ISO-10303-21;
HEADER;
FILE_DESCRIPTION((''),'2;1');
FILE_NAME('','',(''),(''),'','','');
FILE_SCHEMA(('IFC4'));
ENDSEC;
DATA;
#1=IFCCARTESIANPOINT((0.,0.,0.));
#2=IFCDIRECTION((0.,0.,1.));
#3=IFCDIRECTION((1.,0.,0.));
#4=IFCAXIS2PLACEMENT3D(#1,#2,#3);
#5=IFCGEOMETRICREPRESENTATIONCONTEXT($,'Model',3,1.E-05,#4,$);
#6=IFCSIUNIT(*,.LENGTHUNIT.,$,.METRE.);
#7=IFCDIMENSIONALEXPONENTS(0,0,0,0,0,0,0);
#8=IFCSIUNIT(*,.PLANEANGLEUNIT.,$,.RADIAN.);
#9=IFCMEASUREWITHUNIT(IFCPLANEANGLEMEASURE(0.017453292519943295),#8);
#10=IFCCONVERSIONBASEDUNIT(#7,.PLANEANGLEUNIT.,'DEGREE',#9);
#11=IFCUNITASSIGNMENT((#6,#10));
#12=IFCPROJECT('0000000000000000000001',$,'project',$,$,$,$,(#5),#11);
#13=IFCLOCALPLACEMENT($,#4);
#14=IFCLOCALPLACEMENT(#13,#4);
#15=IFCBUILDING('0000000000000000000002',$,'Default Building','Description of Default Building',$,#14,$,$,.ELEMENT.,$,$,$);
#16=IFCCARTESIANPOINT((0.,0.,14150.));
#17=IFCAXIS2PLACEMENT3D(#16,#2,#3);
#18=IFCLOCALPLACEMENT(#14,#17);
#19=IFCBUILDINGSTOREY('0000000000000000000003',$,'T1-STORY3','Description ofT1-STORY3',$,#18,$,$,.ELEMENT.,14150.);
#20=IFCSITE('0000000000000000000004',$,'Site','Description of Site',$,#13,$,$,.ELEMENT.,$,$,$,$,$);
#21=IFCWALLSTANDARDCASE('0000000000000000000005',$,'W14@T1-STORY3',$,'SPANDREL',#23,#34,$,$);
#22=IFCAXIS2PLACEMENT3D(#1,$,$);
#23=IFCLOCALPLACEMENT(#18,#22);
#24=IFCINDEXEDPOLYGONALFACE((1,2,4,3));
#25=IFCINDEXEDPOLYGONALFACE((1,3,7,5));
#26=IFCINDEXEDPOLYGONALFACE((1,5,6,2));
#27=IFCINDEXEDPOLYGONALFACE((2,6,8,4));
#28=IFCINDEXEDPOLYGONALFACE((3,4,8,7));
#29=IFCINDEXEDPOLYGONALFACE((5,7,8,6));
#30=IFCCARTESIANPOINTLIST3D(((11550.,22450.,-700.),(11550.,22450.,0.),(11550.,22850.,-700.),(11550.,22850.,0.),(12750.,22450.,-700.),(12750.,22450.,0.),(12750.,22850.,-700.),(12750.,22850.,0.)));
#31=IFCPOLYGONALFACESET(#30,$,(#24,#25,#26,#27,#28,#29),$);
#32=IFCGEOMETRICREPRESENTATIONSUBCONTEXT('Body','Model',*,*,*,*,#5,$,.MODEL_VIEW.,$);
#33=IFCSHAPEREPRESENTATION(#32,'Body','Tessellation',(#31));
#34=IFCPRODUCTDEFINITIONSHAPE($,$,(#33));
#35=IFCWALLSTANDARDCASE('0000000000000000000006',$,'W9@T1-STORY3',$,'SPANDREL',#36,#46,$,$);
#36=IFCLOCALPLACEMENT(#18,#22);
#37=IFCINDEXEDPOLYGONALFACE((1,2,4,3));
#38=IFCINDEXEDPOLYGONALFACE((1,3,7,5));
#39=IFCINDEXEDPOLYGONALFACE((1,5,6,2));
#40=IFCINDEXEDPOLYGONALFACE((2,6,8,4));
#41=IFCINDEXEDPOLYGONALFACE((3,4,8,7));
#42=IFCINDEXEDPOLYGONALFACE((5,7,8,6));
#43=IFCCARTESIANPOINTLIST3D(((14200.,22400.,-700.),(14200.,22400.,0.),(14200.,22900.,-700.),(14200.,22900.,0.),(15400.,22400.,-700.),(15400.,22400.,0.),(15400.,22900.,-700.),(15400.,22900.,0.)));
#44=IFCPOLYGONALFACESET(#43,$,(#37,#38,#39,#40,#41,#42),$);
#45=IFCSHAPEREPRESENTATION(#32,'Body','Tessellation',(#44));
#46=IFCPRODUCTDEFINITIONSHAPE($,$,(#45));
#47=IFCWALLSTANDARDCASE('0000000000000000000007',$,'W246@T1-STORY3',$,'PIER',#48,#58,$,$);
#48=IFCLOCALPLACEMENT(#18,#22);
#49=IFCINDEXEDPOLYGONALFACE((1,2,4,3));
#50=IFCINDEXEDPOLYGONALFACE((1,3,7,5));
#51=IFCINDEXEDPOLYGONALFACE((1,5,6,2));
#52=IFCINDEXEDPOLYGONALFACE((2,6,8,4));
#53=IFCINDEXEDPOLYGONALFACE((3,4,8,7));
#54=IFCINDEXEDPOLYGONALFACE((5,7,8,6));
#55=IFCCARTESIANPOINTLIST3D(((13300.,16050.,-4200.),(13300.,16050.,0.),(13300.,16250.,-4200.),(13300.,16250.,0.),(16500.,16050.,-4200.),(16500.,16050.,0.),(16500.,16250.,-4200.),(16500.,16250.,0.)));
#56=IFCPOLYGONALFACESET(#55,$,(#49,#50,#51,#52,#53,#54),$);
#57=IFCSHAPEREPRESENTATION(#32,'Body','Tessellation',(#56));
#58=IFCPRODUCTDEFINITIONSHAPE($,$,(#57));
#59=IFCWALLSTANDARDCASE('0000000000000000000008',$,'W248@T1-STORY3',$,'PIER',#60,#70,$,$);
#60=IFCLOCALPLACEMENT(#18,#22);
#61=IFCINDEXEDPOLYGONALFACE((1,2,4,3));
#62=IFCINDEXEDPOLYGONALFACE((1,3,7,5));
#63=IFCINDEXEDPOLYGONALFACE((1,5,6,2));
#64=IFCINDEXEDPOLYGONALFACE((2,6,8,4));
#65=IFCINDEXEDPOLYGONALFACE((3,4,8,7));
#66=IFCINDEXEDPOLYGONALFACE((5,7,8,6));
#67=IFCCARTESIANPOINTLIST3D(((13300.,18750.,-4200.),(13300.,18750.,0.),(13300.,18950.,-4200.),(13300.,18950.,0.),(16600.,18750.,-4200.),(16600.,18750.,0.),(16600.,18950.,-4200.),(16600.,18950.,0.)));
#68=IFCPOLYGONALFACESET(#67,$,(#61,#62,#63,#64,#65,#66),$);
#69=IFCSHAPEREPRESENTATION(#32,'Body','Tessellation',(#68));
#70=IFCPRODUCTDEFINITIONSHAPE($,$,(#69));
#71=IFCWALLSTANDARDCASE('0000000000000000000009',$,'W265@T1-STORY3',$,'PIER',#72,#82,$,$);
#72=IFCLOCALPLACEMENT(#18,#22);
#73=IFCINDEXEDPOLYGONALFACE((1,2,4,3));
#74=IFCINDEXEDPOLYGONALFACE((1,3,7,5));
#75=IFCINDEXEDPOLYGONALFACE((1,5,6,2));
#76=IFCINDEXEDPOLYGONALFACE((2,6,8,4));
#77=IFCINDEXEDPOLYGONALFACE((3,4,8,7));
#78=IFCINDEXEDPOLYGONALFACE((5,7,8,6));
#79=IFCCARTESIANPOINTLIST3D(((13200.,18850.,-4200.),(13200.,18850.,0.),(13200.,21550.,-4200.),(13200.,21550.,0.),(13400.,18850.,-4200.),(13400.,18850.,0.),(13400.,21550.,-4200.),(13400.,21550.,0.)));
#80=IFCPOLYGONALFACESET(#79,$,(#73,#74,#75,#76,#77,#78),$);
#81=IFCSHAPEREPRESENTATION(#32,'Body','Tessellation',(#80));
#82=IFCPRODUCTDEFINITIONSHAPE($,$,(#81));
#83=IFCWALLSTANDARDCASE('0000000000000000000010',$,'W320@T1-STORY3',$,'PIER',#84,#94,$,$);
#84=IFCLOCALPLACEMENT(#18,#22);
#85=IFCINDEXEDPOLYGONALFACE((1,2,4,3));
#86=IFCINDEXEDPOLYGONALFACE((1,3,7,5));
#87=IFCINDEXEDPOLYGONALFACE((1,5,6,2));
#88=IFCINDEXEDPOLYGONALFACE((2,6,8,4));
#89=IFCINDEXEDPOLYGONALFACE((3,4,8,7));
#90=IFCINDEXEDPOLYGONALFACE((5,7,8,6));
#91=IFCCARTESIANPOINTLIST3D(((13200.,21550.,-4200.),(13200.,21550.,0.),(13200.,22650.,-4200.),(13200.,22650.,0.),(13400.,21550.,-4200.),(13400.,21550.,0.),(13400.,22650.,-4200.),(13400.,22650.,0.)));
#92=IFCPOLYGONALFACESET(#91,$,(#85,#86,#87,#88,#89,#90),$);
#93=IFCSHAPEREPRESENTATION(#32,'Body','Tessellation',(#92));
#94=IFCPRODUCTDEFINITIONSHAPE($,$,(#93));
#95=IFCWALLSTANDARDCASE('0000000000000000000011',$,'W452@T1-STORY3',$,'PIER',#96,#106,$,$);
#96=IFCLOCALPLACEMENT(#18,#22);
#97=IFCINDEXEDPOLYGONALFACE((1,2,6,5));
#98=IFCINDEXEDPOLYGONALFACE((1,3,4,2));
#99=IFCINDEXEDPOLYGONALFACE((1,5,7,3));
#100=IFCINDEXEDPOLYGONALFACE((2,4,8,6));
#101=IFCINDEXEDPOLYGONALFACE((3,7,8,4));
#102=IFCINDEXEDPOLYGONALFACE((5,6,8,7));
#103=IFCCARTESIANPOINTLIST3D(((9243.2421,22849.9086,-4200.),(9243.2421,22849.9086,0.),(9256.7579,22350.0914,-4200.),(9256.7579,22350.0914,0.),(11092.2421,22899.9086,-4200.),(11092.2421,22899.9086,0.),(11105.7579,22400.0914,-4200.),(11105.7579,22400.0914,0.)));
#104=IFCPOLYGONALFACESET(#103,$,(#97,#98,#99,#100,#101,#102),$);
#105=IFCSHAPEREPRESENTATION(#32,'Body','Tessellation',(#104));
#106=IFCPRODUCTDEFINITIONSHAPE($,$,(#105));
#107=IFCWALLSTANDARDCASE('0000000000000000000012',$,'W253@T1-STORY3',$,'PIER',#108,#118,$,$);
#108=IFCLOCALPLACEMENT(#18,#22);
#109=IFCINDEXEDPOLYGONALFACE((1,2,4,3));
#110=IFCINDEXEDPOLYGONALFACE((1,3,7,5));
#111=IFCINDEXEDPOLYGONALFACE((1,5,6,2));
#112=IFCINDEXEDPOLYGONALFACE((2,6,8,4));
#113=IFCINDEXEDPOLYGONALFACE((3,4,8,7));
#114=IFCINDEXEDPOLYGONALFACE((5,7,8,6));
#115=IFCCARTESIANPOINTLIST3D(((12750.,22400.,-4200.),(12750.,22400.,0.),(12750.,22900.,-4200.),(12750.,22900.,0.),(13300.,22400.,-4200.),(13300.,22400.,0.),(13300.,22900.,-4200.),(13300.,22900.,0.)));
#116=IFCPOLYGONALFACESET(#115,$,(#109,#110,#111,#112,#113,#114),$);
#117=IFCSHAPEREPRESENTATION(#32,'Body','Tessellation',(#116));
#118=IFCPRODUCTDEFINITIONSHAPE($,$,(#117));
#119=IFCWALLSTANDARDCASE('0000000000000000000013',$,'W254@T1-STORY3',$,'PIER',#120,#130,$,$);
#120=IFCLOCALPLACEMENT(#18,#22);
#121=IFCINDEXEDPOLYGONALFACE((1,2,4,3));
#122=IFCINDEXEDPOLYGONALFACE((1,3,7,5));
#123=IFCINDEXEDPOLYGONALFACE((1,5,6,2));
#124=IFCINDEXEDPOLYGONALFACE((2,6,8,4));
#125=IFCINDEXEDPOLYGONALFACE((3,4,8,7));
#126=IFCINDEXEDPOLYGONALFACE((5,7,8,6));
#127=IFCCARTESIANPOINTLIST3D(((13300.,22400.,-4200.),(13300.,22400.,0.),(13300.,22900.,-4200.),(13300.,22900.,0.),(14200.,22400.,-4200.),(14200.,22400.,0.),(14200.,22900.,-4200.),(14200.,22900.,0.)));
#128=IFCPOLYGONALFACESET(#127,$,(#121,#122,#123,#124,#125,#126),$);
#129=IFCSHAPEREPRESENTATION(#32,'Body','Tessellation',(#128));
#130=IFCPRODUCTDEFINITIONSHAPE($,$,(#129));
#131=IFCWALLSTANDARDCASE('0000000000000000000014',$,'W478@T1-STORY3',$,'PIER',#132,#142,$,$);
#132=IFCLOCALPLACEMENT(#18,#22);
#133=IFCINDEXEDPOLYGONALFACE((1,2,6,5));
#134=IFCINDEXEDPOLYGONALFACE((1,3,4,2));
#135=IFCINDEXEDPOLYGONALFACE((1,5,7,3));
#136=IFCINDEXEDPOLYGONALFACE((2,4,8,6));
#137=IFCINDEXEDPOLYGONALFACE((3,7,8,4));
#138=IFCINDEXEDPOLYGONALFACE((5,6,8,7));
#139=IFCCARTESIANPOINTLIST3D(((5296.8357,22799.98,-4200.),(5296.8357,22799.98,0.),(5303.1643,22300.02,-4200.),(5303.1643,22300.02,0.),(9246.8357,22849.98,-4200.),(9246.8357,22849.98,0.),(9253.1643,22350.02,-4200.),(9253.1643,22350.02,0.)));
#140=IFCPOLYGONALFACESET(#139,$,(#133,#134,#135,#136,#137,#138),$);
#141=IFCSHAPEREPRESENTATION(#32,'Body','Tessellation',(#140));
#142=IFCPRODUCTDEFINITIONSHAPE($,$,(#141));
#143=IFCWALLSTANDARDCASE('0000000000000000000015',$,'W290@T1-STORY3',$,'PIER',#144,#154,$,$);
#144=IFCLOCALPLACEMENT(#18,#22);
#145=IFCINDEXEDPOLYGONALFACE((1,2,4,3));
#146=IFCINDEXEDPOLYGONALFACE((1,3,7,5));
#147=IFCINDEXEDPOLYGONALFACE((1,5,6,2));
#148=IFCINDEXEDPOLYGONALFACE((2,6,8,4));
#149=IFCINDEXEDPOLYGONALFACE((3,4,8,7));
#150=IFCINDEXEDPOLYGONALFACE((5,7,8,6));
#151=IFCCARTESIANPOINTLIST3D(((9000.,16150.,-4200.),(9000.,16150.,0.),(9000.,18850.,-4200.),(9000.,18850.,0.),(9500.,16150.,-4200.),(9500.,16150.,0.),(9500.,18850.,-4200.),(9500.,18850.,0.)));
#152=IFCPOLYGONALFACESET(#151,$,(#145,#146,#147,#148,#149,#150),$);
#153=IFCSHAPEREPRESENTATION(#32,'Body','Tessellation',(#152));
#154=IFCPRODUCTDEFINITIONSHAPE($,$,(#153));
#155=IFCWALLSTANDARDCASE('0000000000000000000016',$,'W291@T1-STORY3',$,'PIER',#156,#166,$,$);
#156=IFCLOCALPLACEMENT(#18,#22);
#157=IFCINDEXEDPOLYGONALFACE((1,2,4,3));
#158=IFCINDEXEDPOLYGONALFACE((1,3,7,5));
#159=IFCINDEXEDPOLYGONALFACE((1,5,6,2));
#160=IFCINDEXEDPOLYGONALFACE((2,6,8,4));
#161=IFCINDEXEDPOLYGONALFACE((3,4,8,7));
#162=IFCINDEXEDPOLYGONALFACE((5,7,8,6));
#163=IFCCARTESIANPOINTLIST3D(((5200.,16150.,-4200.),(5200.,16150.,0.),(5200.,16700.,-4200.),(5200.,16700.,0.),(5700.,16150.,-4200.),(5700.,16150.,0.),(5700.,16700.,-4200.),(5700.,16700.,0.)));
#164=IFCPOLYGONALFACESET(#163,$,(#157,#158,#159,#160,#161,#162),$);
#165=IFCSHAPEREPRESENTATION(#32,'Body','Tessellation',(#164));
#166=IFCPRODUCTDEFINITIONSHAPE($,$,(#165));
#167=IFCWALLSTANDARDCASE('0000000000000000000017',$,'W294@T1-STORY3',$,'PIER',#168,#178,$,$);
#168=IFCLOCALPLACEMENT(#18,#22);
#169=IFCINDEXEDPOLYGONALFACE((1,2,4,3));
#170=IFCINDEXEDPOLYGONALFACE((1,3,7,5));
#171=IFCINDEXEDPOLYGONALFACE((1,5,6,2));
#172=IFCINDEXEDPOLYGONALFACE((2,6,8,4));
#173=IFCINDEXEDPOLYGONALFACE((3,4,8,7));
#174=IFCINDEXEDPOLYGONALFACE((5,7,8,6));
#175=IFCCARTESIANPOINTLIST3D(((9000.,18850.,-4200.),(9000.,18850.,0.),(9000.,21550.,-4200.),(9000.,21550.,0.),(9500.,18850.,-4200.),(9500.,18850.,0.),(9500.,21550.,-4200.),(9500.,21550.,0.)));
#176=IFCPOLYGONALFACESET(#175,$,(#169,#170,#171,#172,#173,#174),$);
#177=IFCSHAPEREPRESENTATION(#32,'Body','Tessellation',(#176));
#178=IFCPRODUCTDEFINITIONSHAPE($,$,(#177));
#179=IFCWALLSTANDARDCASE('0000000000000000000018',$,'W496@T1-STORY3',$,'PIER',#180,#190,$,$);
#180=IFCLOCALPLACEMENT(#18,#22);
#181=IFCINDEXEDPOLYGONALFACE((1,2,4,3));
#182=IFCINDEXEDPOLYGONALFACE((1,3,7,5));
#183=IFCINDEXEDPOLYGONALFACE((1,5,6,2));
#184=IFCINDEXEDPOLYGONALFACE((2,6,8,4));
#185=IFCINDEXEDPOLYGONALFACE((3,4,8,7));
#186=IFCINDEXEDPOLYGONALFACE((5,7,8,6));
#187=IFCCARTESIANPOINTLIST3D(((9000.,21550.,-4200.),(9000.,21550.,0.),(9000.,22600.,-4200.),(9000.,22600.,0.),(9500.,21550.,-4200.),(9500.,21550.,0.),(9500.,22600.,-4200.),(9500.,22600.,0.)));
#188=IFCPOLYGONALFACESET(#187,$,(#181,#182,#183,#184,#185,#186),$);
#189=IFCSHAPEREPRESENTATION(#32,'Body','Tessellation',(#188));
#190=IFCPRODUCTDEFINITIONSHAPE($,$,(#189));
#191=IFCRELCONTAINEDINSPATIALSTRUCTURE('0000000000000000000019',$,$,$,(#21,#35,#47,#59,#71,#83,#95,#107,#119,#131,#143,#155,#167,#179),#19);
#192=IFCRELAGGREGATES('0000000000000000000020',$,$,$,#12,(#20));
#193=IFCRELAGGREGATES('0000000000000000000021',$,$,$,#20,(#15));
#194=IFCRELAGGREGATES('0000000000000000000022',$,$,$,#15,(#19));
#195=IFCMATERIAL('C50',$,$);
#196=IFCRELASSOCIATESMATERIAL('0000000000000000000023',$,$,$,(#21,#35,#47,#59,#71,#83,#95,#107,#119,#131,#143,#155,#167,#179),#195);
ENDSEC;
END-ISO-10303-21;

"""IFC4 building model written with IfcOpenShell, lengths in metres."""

from ifc_helpers import new_model, entity, si_unit, converted_unit, frame, origin_with_axes, place, context, subcontext, project, spatial, indexed_curve, outline, extrude, material, element, save


model = new_model("IFC4")

# Units and contexts
model_context = context("Model", 3, precision=1e-05, world=origin_with_axes())
body_context = subcontext(model_context, "Body", "Model", "MODEL_VIEW")
ifc_project = project(units=[si_unit("LENGTHUNIT", "METRE"), converted_unit("PLANEANGLEUNIT", "DEGREE", entity("IfcPlaneAngleMeasure", 0.017453292519943295), si_unit("PLANEANGLEUNIT", "RADIAN"), dimensions=[0, 0, 0, 0, 0, 0, 0])], contexts=[model_context])

# Site, building, storey
site_placement = place(None, origin_with_axes())
site = spatial("IfcSite", under=ifc_project, at=site_placement, Name="Site", Description="Description of Site", CompositionType="ELEMENT")
building_placement = place(site_placement, origin_with_axes())
building = spatial("IfcBuilding", under=site, at=building_placement, Name="Default Building", Description="Description of Default Building", CompositionType="ELEMENT")
storey_placement = place(building_placement, frame((0.0, 0.0, 14150.0), z_axis=(0.0, 0.0, 1.0), x_axis=(1.0, 0.0, 0.0)))
storey = spatial("IfcBuildingStorey", under=building, at=storey_placement, Name="T1-STORY3", Description="Description ofT1-STORY3", CompositionType="ELEMENT", Elevation=14150.0)

# Shared definitions
ifc_material_1 = material(Name="C50")

# Walls
wall_1_placement = place(storey_placement, frame((11550.0, 22650.0, -700.0), z_axis=(0.0, 0.0, 1.0), x_axis=(1.0, 0.0, 0.0)))
element("IfcWallStandardCase", 1, at=wall_1_placement, inside=storey, material=ifc_material_1, Name="W14@T1-STORY3", ObjectType="SPANDREL", context=body_context, shape_type="SweptSolid", body=[
    extrude(outline(indexed_curve([(0.0, -200.0), (0.0, 200.0), (1200.0, 200.0), (1200.0, -200.0), (0.0, -200.0)], self_intersect=False)), origin_with_axes(), (0.0, 0.0, 1.0), 700.0),
])
wall_2_placement = place(storey_placement, frame((14200.0, 22650.0, -700.0), z_axis=(0.0, 0.0, 1.0), x_axis=(1.0, 0.0, 0.0)))
element("IfcWallStandardCase", 2, at=wall_2_placement, inside=storey, material=ifc_material_1, Name="W9@T1-STORY3", ObjectType="SPANDREL", context=body_context, shape_type="SweptSolid", body=[
    extrude(outline(indexed_curve([(0.0, -250.0), (0.0, 250.0), (1200.0, 250.0), (1200.0, -250.0), (0.0, -250.0)], self_intersect=False)), origin_with_axes(), (0.0, 0.0, 1.0), 700.0),
])
wall_3_placement = place(storey_placement, frame((13300.0, 16150.0, -4200.0), z_axis=(0.0, 0.0, 1.0), x_axis=(1.0, 0.0, 0.0)))
element("IfcWallStandardCase", 3, at=wall_3_placement, inside=storey, material=ifc_material_1, Name="W246@T1-STORY3", ObjectType="PIER", context=body_context, shape_type="SweptSolid", body=[
    extrude(outline(indexed_curve([(0.0, -100.0), (0.0, 100.0), (3200.0, 100.0), (3200.0, -100.0), (0.0, -100.0)], self_intersect=False)), origin_with_axes(), (0.0, 0.0, 1.0), 4200.0),
])
wall_4_placement = place(storey_placement, frame((13300.0, 18850.0, -4200.0), z_axis=(0.0, 0.0, 1.0), x_axis=(1.0, 0.0, 0.0)))
element("IfcWallStandardCase", 4, at=wall_4_placement, inside=storey, material=ifc_material_1, Name="W248@T1-STORY3", ObjectType="PIER", context=body_context, shape_type="SweptSolid", body=[
    extrude(outline(indexed_curve([(0.0, -100.0), (0.0, 100.0), (3300.0, 100.0), (3300.0, -100.0), (0.0, -100.0)], self_intersect=False)), origin_with_axes(), (0.0, 0.0, 1.0), 4200.0),
])
wall_5_placement = place(storey_placement, frame((13300.0, 18850.0, -4200.0), z_axis=(0.0, 0.0, 1.0), x_axis=(0.0, 1.0, 0.0)))
element("IfcWallStandardCase", 5, at=wall_5_placement, inside=storey, material=ifc_material_1, Name="W265@T1-STORY3", ObjectType="PIER", context=body_context, shape_type="SweptSolid", body=[
    extrude(outline(indexed_curve([(0.0, -100.0), (0.0, 100.0), (2700.0, 100.0), (2700.0, -100.0), (0.0, -100.0)], self_intersect=False)), origin_with_axes(), (0.0, 0.0, 1.0), 4200.0),
])
wall_6_placement = place(storey_placement, frame((13300.0, 21550.0, -4200.0), z_axis=(0.0, 0.0, 1.0), x_axis=(0.0, 1.0, 0.0)))
element("IfcWallStandardCase", 6, at=wall_6_placement, inside=storey, material=ifc_material_1, Name="W320@T1-STORY3", ObjectType="PIER", context=body_context, shape_type="SweptSolid", body=[
    extrude(outline(indexed_curve([(0.0, -100.0), (0.0, 100.0), (1100.0, 100.0), (1100.0, -100.0), (0.0, -100.0)], self_intersect=False)), origin_with_axes(), (0.0, 0.0, 1.0), 4200.0),
])
wall_7_placement = place(storey_placement, frame((9250.0, 22600.0, -4200.0), z_axis=(0.0, 0.0, 1.0), x_axis=(0.999635, 0.027032, 0.0)))
element("IfcWallStandardCase", 7, at=wall_7_placement, inside=storey, material=ifc_material_1, Name="W452@T1-STORY3", ObjectType="PIER", context=body_context, shape_type="SweptSolid", body=[
    extrude(outline(indexed_curve([(0.0, -250.0), (0.0, 250.0), (1849.6759, 250.0), (1849.6759, -250.0), (0.0, -250.0)], self_intersect=False)), origin_with_axes(), (0.0, 0.0, 1.0), 4200.0),
])
wall_8_placement = place(storey_placement, frame((12750.0, 22650.0, -4200.0), z_axis=(0.0, 0.0, 1.0), x_axis=(1.0, 0.0, 0.0)))
element("IfcWallStandardCase", 8, at=wall_8_placement, inside=storey, material=ifc_material_1, Name="W253@T1-STORY3", ObjectType="PIER", context=body_context, shape_type="SweptSolid", body=[
    extrude(outline(indexed_curve([(0.0, -250.0), (0.0, 250.0), (550.0, 250.0), (550.0, -250.0), (0.0, -250.0)], self_intersect=False)), origin_with_axes(), (0.0, 0.0, 1.0), 4200.0),
])
wall_9_placement = place(storey_placement, frame((13300.0, 22650.0, -4200.0), z_axis=(0.0, 0.0, 1.0), x_axis=(1.0, 0.0, 0.0)))
element("IfcWallStandardCase", 9, at=wall_9_placement, inside=storey, material=ifc_material_1, Name="W254@T1-STORY3", ObjectType="PIER", context=body_context, shape_type="SweptSolid", body=[
    extrude(outline(indexed_curve([(0.0, -250.0), (0.0, 250.0), (900.0, 250.0), (900.0, -250.0), (0.0, -250.0)], self_intersect=False)), origin_with_axes(), (0.0, 0.0, 1.0), 4200.0),
])
wall_10_placement = place(storey_placement, frame((5300.0, 22550.0, -4200.0), z_axis=(0.0, 0.0, 1.0), x_axis=(0.99992, 0.012657, 0.0)))
element("IfcWallStandardCase", 10, at=wall_10_placement, inside=storey, material=ifc_material_1, Name="W478@T1-STORY3", ObjectType="PIER", context=body_context, shape_type="SweptSolid", body=[
    extrude(outline(indexed_curve([(0.0, -250.0), (0.0, 250.0), (3950.3164, 250.0), (3950.3164, -250.0), (0.0, -250.0)], self_intersect=False)), origin_with_axes(), (0.0, 0.0, 1.0), 4200.0),
])
wall_11_placement = place(storey_placement, frame((9250.0, 16150.0, -4200.0), z_axis=(0.0, 0.0, 1.0), x_axis=(0.0, 1.0, 0.0)))
element("IfcWallStandardCase", 11, at=wall_11_placement, inside=storey, material=ifc_material_1, Name="W290@T1-STORY3", ObjectType="PIER", context=body_context, shape_type="SweptSolid", body=[
    extrude(outline(indexed_curve([(0.0, -250.0), (0.0, 250.0), (2700.0, 250.0), (2700.0, -250.0), (0.0, -250.0)], self_intersect=False)), origin_with_axes(), (0.0, 0.0, 1.0), 4200.0),
])
wall_12_placement = place(storey_placement, frame((5450.0, 16150.0, -4200.0), z_axis=(0.0, 0.0, 1.0), x_axis=(0.0, 1.0, 0.0)))
element("IfcWallStandardCase", 12, at=wall_12_placement, inside=storey, material=ifc_material_1, Name="W291@T1-STORY3", ObjectType="PIER", context=body_context, shape_type="SweptSolid", body=[
    extrude(outline(indexed_curve([(0.0, -250.0), (0.0, 250.0), (550.0, 250.0), (550.0, -250.0), (0.0, -250.0)], self_intersect=False)), origin_with_axes(), (0.0, 0.0, 1.0), 4200.0),
])
wall_13_placement = place(storey_placement, frame((9250.0, 18850.0, -4200.0), z_axis=(0.0, 0.0, 1.0), x_axis=(0.0, 1.0, 0.0)))
element("IfcWallStandardCase", 13, at=wall_13_placement, inside=storey, material=ifc_material_1, Name="W294@T1-STORY3", ObjectType="PIER", context=body_context, shape_type="SweptSolid", body=[
    extrude(outline(indexed_curve([(0.0, -250.0), (0.0, 250.0), (2700.0, 250.0), (2700.0, -250.0), (0.0, -250.0)], self_intersect=False)), origin_with_axes(), (0.0, 0.0, 1.0), 4200.0),
])
wall_14_placement = place(storey_placement, frame((9250.0, 21550.0, -4200.0), z_axis=(0.0, 0.0, 1.0), x_axis=(0.0, 1.0, 0.0)))
element("IfcWallStandardCase", 14, at=wall_14_placement, inside=storey, material=ifc_material_1, Name="W496@T1-STORY3", ObjectType="PIER", context=body_context, shape_type="SweptSolid", body=[
    extrude(outline(indexed_curve([(0.0, -250.0), (0.0, 250.0), (1050.0, 250.0), (1050.0, -250.0), (0.0, -250.0)], self_intersect=False)), origin_with_axes(), (0.0, 0.0, 1.0), 4200.0),
])

save(model, "model.ifc")
